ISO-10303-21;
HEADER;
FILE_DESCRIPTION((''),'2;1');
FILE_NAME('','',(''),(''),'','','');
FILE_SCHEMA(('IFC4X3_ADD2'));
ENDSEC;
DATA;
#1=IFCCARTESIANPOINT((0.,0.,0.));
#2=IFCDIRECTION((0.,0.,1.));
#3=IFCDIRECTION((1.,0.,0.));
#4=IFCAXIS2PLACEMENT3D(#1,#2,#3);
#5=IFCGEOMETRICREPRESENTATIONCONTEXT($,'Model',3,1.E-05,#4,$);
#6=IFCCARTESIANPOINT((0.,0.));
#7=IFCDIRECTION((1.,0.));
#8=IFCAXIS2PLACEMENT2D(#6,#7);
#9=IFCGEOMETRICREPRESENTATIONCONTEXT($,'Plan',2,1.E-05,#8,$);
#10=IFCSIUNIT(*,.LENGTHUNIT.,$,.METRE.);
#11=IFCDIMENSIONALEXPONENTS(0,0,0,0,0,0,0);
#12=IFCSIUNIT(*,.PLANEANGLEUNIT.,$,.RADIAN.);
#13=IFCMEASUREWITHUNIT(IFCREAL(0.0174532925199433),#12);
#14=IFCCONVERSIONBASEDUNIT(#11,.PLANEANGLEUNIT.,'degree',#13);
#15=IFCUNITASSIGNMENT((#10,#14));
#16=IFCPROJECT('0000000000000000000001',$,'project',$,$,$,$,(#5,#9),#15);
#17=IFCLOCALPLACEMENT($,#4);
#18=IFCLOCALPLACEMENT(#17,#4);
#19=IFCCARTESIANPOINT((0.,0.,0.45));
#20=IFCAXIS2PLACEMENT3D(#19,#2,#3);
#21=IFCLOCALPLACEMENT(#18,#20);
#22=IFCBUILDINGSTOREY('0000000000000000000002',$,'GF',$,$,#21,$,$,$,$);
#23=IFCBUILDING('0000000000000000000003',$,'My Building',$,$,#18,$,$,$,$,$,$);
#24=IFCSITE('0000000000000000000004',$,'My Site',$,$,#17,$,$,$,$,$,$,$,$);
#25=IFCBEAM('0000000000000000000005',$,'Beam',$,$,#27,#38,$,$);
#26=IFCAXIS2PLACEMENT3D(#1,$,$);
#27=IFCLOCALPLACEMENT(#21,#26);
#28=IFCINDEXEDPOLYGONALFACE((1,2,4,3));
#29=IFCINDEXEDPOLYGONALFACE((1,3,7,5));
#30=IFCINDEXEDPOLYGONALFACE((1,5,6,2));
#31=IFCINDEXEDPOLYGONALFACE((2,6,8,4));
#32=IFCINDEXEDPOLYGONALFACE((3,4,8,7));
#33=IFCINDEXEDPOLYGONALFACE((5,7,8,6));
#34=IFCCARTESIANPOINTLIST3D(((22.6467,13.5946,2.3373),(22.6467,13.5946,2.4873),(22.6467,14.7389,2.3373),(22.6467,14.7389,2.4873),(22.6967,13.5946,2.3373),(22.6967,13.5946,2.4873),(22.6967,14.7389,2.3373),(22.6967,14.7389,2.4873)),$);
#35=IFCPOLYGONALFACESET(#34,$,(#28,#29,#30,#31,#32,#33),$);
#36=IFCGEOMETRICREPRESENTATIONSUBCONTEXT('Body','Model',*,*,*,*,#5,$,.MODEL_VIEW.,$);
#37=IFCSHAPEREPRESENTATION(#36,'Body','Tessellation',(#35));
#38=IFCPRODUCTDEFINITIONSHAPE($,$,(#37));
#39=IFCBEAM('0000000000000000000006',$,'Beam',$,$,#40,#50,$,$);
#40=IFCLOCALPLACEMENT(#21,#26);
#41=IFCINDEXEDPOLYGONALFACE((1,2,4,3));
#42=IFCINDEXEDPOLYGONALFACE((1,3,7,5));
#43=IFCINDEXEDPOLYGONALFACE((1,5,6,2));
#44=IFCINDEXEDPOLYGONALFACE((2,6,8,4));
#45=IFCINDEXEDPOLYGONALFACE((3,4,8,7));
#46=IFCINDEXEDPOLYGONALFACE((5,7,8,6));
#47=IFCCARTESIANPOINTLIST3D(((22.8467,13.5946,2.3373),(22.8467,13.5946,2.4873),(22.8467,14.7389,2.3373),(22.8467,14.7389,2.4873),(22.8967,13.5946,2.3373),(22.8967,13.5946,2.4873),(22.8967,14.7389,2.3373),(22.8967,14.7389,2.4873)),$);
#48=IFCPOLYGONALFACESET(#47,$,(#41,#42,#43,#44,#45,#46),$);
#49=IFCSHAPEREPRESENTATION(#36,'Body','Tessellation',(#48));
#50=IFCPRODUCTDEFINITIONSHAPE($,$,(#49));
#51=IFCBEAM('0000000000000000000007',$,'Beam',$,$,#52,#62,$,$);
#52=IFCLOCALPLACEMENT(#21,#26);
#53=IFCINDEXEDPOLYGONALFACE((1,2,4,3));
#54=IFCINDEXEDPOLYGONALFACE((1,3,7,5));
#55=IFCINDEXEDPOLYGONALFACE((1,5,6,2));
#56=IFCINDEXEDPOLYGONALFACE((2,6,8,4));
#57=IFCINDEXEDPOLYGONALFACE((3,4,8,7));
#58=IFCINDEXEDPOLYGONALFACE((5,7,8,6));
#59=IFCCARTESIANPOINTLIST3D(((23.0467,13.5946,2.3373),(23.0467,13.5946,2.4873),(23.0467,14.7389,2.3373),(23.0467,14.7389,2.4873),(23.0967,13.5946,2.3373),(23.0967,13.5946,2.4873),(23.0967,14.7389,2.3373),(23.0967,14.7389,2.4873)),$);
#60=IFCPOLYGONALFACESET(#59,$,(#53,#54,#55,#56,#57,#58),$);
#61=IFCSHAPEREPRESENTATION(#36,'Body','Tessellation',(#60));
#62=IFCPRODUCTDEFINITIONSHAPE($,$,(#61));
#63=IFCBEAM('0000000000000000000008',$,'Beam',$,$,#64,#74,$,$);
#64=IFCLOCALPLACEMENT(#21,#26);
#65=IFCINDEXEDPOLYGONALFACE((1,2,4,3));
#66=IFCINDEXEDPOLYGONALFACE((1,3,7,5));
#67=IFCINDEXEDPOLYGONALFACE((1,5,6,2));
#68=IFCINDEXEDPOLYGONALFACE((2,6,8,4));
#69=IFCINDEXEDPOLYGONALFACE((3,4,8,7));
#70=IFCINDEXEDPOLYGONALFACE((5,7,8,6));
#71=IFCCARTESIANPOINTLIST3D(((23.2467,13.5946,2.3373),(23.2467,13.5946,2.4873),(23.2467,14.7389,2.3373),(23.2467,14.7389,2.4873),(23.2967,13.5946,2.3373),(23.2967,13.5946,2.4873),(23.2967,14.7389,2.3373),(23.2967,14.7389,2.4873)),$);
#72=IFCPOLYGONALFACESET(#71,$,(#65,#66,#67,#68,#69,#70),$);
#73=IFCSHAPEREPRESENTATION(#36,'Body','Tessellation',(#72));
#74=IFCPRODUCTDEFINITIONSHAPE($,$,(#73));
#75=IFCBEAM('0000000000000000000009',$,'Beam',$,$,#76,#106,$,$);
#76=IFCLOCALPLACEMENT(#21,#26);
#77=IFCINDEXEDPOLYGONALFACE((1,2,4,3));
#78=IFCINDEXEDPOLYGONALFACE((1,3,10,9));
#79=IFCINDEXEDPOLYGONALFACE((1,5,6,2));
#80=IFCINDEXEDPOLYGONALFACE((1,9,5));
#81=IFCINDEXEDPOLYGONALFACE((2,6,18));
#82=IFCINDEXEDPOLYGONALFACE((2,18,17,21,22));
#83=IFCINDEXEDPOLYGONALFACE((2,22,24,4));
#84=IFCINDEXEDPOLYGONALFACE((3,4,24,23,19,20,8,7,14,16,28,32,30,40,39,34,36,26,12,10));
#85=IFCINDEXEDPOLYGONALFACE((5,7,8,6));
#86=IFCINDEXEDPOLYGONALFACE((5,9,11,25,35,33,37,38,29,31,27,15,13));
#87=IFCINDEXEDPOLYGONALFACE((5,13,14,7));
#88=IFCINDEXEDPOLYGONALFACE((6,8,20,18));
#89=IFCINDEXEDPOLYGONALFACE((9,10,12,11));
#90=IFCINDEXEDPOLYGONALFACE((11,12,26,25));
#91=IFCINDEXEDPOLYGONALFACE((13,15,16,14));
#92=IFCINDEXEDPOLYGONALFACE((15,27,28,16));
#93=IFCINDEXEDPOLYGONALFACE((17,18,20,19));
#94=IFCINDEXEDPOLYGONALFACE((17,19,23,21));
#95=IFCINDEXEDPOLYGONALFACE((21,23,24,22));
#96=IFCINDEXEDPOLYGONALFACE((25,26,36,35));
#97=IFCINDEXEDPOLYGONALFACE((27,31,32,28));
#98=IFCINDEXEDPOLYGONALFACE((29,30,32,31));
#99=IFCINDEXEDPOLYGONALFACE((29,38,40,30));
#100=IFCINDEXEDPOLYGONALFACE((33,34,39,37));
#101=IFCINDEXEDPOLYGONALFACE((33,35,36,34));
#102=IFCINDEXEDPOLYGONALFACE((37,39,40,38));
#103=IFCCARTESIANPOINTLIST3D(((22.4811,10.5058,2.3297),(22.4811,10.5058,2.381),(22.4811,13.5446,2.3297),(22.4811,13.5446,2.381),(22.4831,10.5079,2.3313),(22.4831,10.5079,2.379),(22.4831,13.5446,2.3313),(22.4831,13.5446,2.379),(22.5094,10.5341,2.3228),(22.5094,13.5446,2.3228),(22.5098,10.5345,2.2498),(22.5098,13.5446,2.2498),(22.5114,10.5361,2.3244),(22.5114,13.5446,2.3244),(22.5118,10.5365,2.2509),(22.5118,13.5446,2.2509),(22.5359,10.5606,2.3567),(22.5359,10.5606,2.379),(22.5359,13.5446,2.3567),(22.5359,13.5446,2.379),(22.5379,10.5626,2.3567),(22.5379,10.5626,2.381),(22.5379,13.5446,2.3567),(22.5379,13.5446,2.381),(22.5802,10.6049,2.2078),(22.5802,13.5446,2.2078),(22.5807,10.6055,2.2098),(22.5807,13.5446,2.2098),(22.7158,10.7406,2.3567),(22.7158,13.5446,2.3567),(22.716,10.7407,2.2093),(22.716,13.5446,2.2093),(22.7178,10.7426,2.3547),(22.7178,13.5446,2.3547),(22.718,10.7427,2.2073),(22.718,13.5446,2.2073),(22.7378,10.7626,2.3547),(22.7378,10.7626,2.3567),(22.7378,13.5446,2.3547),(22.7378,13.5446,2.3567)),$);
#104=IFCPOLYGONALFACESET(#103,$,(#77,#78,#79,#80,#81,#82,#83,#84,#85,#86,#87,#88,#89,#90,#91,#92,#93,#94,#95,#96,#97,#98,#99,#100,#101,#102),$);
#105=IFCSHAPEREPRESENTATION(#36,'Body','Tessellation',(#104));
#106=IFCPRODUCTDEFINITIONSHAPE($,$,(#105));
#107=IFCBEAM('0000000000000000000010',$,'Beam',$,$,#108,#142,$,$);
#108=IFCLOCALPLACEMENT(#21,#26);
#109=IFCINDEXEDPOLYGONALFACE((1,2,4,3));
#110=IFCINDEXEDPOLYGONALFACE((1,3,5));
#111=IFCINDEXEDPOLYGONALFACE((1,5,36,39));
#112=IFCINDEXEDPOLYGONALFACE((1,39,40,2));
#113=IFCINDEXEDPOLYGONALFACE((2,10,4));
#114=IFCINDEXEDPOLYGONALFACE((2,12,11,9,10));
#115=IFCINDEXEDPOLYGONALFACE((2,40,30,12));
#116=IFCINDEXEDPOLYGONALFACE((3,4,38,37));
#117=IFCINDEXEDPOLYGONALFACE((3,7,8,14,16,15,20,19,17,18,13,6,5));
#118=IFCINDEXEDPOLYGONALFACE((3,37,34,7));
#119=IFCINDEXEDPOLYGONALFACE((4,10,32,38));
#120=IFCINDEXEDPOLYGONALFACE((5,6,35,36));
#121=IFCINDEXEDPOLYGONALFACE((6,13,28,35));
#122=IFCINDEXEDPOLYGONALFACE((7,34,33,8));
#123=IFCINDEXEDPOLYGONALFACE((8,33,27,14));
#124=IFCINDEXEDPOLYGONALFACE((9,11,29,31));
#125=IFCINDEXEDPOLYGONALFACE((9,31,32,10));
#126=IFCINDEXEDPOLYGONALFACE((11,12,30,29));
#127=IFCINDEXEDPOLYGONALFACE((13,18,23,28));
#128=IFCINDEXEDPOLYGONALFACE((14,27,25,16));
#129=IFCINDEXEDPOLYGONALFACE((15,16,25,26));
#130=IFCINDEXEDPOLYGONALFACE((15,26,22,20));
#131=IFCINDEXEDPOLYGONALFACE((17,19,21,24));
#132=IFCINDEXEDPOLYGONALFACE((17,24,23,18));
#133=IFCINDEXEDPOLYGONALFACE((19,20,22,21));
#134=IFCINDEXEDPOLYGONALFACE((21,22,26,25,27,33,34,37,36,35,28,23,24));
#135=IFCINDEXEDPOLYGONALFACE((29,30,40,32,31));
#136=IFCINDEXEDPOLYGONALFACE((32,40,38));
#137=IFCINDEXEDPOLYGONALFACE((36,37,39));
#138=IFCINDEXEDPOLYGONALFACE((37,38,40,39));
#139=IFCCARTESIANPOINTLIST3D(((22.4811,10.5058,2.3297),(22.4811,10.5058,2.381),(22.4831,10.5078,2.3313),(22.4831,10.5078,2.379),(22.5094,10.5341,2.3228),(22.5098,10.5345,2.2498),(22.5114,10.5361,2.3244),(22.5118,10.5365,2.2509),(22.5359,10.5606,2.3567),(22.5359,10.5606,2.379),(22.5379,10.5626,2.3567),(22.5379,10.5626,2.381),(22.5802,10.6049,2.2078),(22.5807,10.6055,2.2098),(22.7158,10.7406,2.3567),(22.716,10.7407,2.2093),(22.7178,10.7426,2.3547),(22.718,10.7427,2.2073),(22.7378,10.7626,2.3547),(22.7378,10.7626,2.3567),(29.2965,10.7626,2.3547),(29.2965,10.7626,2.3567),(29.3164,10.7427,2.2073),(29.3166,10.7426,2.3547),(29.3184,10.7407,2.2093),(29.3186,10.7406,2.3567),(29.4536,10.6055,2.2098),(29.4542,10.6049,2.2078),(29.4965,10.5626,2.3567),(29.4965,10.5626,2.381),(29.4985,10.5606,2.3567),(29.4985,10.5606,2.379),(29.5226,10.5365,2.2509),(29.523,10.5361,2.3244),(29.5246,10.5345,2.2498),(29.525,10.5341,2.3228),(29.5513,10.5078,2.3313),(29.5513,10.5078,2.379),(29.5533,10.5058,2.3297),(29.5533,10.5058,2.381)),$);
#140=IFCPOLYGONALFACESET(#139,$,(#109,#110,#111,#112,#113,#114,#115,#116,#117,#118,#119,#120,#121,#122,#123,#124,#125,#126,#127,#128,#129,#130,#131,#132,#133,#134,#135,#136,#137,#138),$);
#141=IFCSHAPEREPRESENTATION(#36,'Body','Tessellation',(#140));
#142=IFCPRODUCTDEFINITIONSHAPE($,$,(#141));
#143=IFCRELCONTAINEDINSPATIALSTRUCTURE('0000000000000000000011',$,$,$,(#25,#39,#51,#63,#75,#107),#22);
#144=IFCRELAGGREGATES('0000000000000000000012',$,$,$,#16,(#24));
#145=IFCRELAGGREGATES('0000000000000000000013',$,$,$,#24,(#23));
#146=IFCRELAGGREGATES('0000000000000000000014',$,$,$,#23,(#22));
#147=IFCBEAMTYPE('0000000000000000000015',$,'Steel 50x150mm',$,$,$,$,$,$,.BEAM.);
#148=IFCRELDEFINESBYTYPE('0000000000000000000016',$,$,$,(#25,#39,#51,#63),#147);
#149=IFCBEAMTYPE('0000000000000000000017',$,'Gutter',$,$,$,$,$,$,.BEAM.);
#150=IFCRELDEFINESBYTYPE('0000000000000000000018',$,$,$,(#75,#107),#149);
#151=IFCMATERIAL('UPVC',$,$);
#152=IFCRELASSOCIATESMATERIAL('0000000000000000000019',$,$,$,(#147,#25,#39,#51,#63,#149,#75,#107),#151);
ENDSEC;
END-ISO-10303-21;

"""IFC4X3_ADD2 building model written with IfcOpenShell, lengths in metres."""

from ifc_helpers import new_model, entity, si_unit, converted_unit, frame, origin_with_axes, origin_2d_with_axis, place, context, subcontext, project, spatial, indexed_curve, rectangle, outline, extrude, clip, halfspace, material, material_profile, profile_set, profile_usage, type_object, element, save


model = new_model("IFC4X3_ADD2")

# Units and contexts
model_context = context("Model", 3, precision=1e-05, world=origin_with_axes())
plan_context = context("Plan", 2, precision=1e-05, world=origin_2d_with_axis())
body_context_1 = subcontext(model_context, "Body", "Model", "MODEL_VIEW")
ifc_project = project(units=[si_unit("LENGTHUNIT", "METRE"), converted_unit("PLANEANGLEUNIT", "degree", entity("IfcReal", 0.0174532925199433), si_unit("PLANEANGLEUNIT", "RADIAN"), dimensions=[0, 0, 0, 0, 0, 0, 0])], contexts=[model_context, plan_context])

# Site, building, storey
site_placement = place(None, origin_with_axes())
site = spatial("IfcSite", under=ifc_project, at=site_placement, Name="My Site")
building_placement = place(site_placement, origin_with_axes())
building = spatial("IfcBuilding", under=site, at=building_placement, Name="My Building")
storey_placement = place(building_placement, frame((0.0, 0.0, 0.45), z_axis=(0.0, 0.0, 1.0), x_axis=(1.0, 0.0, 0.0)))
storey = spatial("IfcBuildingStorey", under=building, at=storey_placement, Name="GF")

# Shared definitions
ifc_material_1 = material(Name="UPVC")

# Beams
ifc_material_profile_1 = material_profile(ifc_material_1, rectangle(XDim=0.05, YDim=0.15))
ifc_profile_set_1 = profile_set([ifc_material_profile_1])
beam_type_1 = type_object("IfcBeamType", Name="Steel 50x150mm", PredefinedType="BEAM", material=ifc_profile_set_1)
ifc_profile_usage_1 = profile_usage(ifc_profile_set_1)
beam_1_placement = place(storey_placement, frame((22.6717, 14.7389, 2.4123), z_axis=(0.0, -1.0, 0.0), x_axis=(1.0, 0.0, 0.0)))
element("IfcBeam", 1, at=beam_1_placement, inside=storey, type_object=beam_type_1, material=ifc_profile_usage_1, Name="Beam", context=body_context_1, shape_type="SweptSolid", body=[
    extrude(rectangle(XDim=0.05, YDim=0.15), origin_with_axes(), (0.0, 0.0, 1.0), 1.1444),
])
ifc_profile_usage_2 = profile_usage(ifc_profile_set_1)
beam_2_placement = place(storey_placement, frame((22.8717, 14.7389, 2.4123), z_axis=(0.0, -1.0, 0.0), x_axis=(1.0, 0.0, 0.0)))
element("IfcBeam", 2, at=beam_2_placement, inside=storey, type_object=beam_type_1, material=ifc_profile_usage_2, Name="Beam", context=body_context_1, shape_type="SweptSolid", body=[
    extrude(rectangle(XDim=0.05, YDim=0.15), origin_with_axes(), (0.0, 0.0, 1.0), 1.1444),
])
ifc_profile_usage_3 = profile_usage(ifc_profile_set_1)
beam_3_placement = place(storey_placement, frame((23.0717, 14.7389, 2.4123), z_axis=(0.0, -1.0, 0.0), x_axis=(1.0, 0.0, 0.0)))
element("IfcBeam", 3, at=beam_3_placement, inside=storey, type_object=beam_type_1, material=ifc_profile_usage_3, Name="Beam", context=body_context_1, shape_type="SweptSolid", body=[
    extrude(rectangle(XDim=0.05, YDim=0.15), origin_with_axes(), (0.0, 0.0, 1.0), 1.1444),
])
ifc_profile_usage_4 = profile_usage(ifc_profile_set_1)
beam_4_placement = place(storey_placement, frame((23.2717, 14.7389, 2.4123), z_axis=(0.0, -1.0, 0.0), x_axis=(1.0, 0.0, 0.0)))
element("IfcBeam", 4, at=beam_4_placement, inside=storey, type_object=beam_type_1, material=ifc_profile_usage_4, Name="Beam", context=body_context_1, shape_type="SweptSolid", body=[
    extrude(rectangle(XDim=0.05, YDim=0.15), origin_with_axes(), (0.0, 0.0, 1.0), 1.1444),
])
ifc_material_profile_2 = material_profile(ifc_material_1, outline(indexed_curve([(0.0548, 0.1717), (0.002, 0.1717), (0.002, 0.124), (0.0303, 0.1171), (0.0307, 0.0436), (0.0996, 0.0025), (0.2349, 0.002), (0.2347, 0.1494), (0.2567, 0.1494), (0.2567, 0.1474), (0.2367, 0.1474), (0.2369, 0.0), (0.0991, 0.0005), (0.0287, 0.0425), (0.0283, 0.1155), (0.0, 0.1224), (0.0, 0.1737), (0.0568, 0.1737), (0.0568, 0.1494), (0.0548, 0.1494), (0.0548, 0.1717)])))
ifc_profile_set_2 = profile_set([ifc_material_profile_2])
ifc_profile_usage_5 = profile_usage(ifc_profile_set_2, cardinal=5)
beam_type_2 = type_object("IfcBeamType", Name="Gutter", PredefinedType="BEAM", material=ifc_profile_set_2)
beam_5_placement = place(storey_placement, frame((22.4811, 13.5446, 2.2073), z_axis=(0.0, -1.0, 0.0), x_axis=(1.0, 0.0, 0.0)))
element("IfcBeam", 5, at=beam_5_placement, inside=storey, type_object=beam_type_2, material=ifc_profile_usage_5, Name="Beam", context=body_context_1, shape_type="Clipping", body=[
    clip(extrude(outline(indexed_curve([(0.0548, 0.1717), (0.002, 0.1717), (0.002, 0.124), (0.0303, 0.1171), (0.0307, 0.0436), (0.0996, 0.0025), (0.2349, 0.002), (0.2347, 0.1494), (0.2567, 0.1494), (0.2567, 0.1474), (0.2367, 0.1474), (0.2369, 0.0), (0.0991, 0.0005), (0.0287, 0.0425), (0.0283, 0.1155), (0.0, 0.1224), (0.0, 0.1737), (0.0568, 0.1737), (0.0568, 0.1494), (0.0548, 0.1494), (0.0548, 0.1717)])), origin_with_axes(), (0.0, 0.0, 1.0), 3.0387), halfspace(frame((0.0, -2.8276, 3.0387), z_axis=(0.707107, 0.0, 0.707107), x_axis=(0.0, -1.0, 0.0)), False)),
])
ifc_profile_usage_6 = profile_usage(ifc_profile_set_2, cardinal=5)
beam_6_placement = place(storey_placement, frame((22.4811, 10.5058, 2.2073), z_axis=(1.0, 0.0, 0.0), x_axis=(0.0, 1.0, 0.0)))
element("IfcBeam", 6, at=beam_6_placement, inside=storey, type_object=beam_type_2, material=ifc_profile_usage_6, Name="Beam", context=body_context_1, shape_type="Clipping", body=[
    clip(clip(extrude(outline(indexed_curve([(0.0548, 0.1717), (0.002, 0.1717), (0.002, 0.124), (0.0303, 0.1171), (0.0307, 0.0436), (0.0996, 0.0025), (0.2349, 0.002), (0.2347, 0.1494), (0.2567, 0.1494), (0.2567, 0.1474), (0.2367, 0.1474), (0.2369, 0.0), (0.0991, 0.0005), (0.0287, 0.0425), (0.0283, 0.1155), (0.0, 0.1224), (0.0, 0.1737), (0.0568, 0.1737), (0.0568, 0.1494), (0.0548, 0.1494), (0.0548, 0.1717)])), origin_with_axes(), (0.0, 0.0, 1.0), 7.0722), halfspace(frame((0.0, -2.8276, 7.0722), z_axis=(0.707107, 0.0, 0.707106), x_axis=(0.0, -1.0, 0.0)), False)), halfspace(frame((0.0, -2.8276, 0.0), z_axis=(0.707106, 0.0, -0.707107), x_axis=(0.0, -1.0, 0.0)), False)),
])

save(model, "model.ifc")
